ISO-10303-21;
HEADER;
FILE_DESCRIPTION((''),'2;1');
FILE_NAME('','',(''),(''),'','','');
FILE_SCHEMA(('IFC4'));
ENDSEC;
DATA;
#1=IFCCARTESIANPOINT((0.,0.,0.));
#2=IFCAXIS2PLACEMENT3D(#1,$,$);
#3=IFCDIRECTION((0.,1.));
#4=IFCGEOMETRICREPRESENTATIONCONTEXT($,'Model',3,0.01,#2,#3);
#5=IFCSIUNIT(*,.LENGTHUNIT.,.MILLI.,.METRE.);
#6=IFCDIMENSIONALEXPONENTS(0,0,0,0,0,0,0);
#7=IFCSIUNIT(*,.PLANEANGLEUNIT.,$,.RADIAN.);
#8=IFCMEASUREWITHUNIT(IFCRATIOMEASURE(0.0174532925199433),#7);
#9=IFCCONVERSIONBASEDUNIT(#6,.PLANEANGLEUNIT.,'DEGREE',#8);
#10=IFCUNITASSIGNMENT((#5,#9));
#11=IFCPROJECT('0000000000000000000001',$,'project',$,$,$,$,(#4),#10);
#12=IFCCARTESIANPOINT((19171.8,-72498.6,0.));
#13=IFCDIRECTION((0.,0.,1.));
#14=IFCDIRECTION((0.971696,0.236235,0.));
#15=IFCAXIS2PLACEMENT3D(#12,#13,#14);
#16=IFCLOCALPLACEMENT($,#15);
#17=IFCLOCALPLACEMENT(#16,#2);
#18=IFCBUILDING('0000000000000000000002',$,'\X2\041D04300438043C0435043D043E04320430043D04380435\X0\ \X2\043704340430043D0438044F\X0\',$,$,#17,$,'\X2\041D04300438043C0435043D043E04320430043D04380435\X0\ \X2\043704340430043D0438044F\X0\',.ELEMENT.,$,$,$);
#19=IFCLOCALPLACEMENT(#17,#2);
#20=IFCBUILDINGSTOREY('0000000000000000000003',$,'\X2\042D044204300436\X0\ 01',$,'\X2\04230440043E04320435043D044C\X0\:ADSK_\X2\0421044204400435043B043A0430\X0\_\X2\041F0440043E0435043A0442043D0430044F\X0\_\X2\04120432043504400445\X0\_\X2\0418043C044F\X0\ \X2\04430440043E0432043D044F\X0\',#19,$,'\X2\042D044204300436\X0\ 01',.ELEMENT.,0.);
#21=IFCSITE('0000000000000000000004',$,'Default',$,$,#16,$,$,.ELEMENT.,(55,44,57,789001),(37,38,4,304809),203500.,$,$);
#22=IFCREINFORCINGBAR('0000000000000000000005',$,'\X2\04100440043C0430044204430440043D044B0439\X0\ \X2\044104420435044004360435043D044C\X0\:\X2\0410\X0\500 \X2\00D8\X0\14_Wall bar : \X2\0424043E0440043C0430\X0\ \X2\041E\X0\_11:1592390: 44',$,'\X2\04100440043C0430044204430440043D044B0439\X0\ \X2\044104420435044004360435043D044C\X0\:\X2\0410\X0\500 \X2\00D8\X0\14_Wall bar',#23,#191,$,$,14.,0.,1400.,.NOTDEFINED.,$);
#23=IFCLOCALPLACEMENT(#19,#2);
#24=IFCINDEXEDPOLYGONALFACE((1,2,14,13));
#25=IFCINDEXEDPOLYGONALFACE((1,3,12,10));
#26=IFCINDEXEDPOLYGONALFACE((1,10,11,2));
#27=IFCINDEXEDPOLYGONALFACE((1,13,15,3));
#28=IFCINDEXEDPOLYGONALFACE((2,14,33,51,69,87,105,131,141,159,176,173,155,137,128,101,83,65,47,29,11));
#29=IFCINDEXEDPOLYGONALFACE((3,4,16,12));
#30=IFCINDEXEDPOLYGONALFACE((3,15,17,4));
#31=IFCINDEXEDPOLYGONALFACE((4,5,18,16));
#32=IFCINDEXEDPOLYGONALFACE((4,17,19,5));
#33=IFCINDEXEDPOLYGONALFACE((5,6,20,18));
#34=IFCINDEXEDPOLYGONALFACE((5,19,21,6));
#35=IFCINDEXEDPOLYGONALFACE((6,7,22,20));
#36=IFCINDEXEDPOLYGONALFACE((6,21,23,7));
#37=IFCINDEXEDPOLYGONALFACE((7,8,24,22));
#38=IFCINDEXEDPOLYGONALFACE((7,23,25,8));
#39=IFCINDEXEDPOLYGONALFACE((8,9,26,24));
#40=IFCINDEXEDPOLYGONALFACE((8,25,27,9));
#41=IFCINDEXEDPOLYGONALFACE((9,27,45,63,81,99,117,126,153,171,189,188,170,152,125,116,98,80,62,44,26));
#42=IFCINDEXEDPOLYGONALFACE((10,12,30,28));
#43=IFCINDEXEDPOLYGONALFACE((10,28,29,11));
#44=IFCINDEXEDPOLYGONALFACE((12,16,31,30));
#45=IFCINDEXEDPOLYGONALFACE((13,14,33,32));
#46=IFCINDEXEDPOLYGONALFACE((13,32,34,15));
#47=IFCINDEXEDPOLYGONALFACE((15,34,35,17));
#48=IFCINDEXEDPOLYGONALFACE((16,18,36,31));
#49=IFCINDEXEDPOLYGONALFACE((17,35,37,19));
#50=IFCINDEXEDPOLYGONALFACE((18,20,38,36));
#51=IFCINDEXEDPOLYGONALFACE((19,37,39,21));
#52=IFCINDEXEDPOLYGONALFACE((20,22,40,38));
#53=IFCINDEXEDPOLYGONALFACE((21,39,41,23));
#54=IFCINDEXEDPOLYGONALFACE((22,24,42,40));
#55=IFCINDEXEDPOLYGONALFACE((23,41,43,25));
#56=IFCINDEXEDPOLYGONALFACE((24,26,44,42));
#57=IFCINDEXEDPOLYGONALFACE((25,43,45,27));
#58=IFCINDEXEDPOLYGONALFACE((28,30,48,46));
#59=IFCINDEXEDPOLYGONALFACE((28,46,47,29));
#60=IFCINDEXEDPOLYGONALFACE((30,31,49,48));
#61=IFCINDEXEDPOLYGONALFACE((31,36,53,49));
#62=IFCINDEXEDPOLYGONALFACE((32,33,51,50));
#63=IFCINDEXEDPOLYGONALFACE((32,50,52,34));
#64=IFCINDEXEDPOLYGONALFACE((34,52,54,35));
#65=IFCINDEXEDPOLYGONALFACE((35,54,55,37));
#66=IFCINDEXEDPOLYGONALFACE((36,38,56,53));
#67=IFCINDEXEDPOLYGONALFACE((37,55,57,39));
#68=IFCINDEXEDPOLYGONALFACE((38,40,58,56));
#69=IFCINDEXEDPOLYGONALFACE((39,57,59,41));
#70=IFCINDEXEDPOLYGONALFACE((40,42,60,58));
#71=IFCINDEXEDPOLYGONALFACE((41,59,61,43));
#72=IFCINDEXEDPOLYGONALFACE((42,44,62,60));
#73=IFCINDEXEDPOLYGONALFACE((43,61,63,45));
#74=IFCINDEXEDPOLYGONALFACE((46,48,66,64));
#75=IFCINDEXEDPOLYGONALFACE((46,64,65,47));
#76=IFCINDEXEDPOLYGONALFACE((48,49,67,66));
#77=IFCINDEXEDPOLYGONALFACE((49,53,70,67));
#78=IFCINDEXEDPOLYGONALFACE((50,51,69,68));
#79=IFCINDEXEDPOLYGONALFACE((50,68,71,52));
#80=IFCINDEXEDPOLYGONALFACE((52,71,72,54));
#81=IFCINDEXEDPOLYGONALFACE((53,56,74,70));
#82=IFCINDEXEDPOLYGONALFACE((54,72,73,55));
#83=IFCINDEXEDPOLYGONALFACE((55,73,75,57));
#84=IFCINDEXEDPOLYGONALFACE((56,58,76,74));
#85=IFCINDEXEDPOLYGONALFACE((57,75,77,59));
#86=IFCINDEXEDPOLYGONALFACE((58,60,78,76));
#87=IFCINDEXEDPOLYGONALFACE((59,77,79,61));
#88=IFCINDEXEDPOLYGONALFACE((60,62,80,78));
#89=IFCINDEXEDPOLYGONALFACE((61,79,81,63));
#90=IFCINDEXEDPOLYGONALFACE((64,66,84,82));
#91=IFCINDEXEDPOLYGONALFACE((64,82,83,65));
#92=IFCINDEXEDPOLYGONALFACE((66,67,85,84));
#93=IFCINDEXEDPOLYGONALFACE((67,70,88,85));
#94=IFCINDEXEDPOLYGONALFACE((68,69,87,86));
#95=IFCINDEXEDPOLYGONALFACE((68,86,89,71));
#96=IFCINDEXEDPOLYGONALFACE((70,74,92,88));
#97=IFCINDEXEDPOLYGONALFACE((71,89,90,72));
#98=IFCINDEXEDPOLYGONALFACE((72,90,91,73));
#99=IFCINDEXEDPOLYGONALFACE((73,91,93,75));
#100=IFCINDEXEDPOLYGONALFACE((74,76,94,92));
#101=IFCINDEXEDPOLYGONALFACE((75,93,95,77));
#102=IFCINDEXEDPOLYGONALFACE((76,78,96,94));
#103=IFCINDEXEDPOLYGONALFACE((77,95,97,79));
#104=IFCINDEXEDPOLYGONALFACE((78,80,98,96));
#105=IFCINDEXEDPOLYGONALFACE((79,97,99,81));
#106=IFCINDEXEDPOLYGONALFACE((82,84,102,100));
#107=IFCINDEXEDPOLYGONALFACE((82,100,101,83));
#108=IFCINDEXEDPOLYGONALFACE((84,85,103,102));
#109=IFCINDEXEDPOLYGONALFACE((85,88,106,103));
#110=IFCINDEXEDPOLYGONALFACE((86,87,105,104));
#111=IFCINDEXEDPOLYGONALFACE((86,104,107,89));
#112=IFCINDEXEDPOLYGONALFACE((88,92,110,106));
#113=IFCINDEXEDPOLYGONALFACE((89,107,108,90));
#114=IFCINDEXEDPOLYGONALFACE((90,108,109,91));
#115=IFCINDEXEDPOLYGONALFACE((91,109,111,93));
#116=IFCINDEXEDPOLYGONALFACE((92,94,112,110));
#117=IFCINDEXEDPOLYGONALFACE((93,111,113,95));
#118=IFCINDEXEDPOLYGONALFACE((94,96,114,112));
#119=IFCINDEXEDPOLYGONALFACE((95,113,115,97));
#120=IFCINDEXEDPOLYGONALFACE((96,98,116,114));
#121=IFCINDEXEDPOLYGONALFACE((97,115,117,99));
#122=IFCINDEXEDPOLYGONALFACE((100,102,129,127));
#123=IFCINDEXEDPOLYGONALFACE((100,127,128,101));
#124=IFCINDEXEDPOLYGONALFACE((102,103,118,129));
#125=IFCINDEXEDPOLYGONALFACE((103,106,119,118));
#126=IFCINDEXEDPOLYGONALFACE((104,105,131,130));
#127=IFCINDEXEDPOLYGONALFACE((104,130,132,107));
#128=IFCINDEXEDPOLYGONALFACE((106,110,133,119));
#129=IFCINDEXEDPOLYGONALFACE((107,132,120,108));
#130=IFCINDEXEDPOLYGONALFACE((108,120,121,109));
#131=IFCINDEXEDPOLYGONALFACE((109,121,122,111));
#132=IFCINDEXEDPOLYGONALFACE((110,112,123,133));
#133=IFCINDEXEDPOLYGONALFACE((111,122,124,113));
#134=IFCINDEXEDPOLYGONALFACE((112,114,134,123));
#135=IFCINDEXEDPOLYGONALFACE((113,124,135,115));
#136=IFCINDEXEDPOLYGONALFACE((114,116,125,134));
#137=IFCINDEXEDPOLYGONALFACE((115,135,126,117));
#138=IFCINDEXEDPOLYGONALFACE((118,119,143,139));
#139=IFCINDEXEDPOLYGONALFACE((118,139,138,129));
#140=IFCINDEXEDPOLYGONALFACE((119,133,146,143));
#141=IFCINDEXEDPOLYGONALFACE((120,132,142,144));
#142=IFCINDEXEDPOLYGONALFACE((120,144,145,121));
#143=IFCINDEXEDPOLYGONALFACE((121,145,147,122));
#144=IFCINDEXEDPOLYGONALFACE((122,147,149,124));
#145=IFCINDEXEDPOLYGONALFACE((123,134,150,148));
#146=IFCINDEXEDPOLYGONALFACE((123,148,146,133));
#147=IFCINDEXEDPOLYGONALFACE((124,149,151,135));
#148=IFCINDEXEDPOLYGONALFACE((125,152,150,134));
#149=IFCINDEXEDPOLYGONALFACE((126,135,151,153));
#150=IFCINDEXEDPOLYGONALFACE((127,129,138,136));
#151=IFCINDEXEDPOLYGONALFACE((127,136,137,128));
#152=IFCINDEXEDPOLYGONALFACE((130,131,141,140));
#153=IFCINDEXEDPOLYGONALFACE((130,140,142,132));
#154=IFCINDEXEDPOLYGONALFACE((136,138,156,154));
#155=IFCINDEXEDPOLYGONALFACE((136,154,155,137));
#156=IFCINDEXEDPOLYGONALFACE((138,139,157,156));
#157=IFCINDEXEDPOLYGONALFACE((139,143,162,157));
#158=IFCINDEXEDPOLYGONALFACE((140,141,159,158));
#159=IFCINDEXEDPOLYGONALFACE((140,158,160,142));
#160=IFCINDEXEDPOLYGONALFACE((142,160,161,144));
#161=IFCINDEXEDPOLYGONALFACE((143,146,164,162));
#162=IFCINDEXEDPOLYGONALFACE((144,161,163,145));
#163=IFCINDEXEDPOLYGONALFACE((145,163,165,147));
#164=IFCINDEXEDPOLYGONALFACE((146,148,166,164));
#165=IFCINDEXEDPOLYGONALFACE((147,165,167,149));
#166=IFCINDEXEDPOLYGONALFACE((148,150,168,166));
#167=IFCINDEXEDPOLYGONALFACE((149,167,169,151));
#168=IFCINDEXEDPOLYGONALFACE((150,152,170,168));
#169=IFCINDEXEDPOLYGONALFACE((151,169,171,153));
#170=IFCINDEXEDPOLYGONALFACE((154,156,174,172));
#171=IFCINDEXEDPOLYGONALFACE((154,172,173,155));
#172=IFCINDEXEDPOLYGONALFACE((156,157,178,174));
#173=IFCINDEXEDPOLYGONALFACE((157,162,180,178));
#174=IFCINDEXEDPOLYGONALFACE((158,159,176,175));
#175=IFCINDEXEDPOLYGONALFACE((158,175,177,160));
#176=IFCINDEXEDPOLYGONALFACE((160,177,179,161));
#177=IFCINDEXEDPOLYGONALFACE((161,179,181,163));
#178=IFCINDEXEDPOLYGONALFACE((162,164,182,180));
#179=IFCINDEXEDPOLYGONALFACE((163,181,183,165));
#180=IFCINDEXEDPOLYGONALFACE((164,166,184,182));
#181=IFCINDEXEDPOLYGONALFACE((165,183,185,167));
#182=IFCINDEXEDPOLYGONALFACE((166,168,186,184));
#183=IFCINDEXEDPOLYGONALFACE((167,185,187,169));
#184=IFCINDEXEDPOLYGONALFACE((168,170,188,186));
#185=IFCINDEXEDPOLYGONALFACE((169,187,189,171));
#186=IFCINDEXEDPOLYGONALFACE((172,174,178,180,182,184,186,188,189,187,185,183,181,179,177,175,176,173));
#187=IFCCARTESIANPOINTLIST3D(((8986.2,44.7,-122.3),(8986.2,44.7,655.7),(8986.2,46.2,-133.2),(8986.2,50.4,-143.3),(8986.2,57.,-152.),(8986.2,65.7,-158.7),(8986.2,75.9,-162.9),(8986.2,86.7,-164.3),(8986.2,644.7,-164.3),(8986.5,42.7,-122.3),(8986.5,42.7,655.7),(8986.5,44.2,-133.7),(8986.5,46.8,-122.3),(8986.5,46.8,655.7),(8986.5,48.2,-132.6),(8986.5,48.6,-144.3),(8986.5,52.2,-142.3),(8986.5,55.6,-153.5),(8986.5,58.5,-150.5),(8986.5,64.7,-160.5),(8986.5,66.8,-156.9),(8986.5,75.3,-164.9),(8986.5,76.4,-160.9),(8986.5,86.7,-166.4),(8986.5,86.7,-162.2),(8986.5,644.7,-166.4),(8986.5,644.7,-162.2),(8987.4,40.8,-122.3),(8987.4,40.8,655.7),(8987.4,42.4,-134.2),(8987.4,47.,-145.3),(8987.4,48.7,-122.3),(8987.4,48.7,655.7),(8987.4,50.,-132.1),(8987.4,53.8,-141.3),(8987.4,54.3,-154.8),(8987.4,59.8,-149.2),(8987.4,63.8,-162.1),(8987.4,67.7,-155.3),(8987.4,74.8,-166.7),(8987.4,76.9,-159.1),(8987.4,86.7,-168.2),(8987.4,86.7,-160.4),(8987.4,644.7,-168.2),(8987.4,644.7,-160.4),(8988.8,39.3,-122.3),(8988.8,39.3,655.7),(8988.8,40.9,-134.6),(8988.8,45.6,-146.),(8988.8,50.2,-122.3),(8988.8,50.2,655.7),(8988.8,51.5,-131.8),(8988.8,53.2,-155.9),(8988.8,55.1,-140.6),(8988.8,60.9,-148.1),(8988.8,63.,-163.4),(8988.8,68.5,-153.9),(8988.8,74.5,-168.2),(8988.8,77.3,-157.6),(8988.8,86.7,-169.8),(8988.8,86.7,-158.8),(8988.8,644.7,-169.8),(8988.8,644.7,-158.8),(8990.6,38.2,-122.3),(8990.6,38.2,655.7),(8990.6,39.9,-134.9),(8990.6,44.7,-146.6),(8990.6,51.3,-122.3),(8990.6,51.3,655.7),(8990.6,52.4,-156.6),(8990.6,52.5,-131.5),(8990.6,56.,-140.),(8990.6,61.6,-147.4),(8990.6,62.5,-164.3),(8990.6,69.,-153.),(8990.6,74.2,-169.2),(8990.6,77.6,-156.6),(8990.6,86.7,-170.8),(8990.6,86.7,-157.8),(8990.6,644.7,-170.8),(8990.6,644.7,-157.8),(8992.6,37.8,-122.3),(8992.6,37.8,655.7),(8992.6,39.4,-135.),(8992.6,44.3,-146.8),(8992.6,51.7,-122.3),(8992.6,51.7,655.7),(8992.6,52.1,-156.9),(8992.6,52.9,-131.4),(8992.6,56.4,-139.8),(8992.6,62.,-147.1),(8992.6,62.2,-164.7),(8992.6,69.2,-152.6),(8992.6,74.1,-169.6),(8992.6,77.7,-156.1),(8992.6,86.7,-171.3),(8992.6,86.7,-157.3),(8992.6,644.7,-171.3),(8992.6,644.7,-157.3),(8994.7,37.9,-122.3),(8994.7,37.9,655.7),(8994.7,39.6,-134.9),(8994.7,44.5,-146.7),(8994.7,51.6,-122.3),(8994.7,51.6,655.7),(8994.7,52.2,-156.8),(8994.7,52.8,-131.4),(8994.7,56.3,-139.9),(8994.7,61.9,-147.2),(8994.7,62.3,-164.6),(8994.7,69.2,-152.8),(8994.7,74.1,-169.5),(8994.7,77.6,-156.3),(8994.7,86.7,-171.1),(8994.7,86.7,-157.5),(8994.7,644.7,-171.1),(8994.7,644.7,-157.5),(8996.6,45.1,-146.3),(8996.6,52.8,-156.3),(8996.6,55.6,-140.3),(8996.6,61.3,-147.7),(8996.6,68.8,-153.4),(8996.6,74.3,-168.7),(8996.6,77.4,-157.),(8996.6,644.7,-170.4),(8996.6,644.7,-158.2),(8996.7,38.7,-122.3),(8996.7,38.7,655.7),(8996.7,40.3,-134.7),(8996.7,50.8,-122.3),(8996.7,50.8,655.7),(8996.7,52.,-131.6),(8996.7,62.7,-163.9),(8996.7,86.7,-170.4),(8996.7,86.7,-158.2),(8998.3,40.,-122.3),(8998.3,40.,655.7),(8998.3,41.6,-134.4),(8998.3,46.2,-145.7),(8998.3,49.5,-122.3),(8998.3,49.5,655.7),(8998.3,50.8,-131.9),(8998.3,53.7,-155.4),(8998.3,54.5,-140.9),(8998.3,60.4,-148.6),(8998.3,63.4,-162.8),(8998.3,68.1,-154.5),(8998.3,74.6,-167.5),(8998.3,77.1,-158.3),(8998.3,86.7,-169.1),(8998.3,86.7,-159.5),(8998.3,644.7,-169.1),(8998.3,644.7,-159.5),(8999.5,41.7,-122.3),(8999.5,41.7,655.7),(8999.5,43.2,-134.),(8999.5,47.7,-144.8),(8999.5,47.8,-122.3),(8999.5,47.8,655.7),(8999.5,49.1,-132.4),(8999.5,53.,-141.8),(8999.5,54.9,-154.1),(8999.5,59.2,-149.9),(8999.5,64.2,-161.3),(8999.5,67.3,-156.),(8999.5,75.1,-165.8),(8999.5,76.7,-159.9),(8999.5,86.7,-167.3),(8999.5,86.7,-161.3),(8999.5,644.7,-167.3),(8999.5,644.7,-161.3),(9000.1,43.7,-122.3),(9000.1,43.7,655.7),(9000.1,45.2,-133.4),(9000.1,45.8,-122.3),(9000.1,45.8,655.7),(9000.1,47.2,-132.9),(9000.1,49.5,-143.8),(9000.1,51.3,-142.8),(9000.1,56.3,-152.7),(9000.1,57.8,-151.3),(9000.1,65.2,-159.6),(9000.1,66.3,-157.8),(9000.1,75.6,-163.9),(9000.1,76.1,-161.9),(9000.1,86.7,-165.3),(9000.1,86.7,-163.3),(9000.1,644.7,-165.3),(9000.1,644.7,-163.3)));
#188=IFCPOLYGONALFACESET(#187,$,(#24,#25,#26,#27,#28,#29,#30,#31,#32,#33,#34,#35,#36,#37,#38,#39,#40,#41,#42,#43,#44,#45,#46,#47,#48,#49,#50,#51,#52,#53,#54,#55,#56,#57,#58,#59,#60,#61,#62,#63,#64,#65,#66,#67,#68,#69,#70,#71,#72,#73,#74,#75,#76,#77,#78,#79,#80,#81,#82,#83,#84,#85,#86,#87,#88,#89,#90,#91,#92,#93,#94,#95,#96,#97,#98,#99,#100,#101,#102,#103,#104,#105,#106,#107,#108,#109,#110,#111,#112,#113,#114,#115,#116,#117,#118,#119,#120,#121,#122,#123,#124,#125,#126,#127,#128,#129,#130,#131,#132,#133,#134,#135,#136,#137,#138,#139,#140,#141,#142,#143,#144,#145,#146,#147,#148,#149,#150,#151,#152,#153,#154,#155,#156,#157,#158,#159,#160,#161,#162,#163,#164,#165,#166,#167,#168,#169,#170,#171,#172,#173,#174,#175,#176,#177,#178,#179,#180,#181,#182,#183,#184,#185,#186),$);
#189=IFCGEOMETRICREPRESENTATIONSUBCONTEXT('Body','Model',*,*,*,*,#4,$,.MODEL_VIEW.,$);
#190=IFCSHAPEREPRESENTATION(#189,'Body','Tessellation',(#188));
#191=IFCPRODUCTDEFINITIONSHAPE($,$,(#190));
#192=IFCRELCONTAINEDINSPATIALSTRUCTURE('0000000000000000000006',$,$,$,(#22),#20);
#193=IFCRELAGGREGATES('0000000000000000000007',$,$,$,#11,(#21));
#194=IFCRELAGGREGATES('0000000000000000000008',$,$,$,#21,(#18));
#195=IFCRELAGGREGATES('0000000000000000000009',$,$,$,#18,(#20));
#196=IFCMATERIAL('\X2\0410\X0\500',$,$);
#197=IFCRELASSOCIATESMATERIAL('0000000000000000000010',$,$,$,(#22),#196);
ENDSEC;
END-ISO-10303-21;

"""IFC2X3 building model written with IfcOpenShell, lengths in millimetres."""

from ifc_helpers import new_model, entity, si_unit, converted_unit, direction, frame, origin, place, context, subcontext, project, spatial, material, element, save


model = new_model("IFC2X3")

# Units and contexts
model_context = context("Model", 3, precision=0.01, world=origin(), true_north=direction((0.0, 1.0)))
body_context = subcontext(model_context, "Body", "Model", "MODEL_VIEW")
ifc_project = project(units=[si_unit("LENGTHUNIT", "METRE", prefix="MILLI"), converted_unit("PLANEANGLEUNIT", "DEGREE", entity("IfcRatioMeasure", 0.0174532925199433), si_unit("PLANEANGLEUNIT", "RADIAN"), dimensions=[0, 0, 0, 0, 0, 0, 0])], contexts=[model_context])

# Site, building, storey
site_placement = place(None, frame((19171.8, -72498.6, 0.0), z_axis=(0.0, 0.0, 1.0), x_axis=(0.971696, 0.236235, 0.0)))
site = spatial("IfcSite", under=ifc_project, at=site_placement, Name="Default", CompositionType="ELEMENT", RefLatitude=(55, 44, 57, 789001), RefLongitude=(37, 38, 4, 304809), RefElevation=203500.0)
building_placement = place(site_placement, origin())
building = spatial("IfcBuilding", under=site, at=building_placement, Name="Наименование здания", LongName="Наименование здания", CompositionType="ELEMENT")
storey_placement = place(building_placement, origin())
storey = spatial("IfcBuildingStorey", under=building, at=storey_placement, Name="Этаж 01", ObjectType="Уровень:ADSK_Стрелка_Проектная_Вверх_Имя уровня", LongName="Этаж 01", CompositionType="ELEMENT", Elevation=0.0)

# Reinforcing bar
ifc_material = material(Name="А500")
placement = place(storey_placement, origin())
element("IfcReinforcingBar", 1, at=placement, inside=storey, material=ifc_material, Name="Арматурный стержень:А500 Ø14_Wall bar : Форма О_11:1592390: 44", ObjectType="Арматурный стержень:А500 Ø14_Wall bar", BarLength=1400.0, BarRole="NOTDEFINED", CrossSectionArea=0.0, NominalDiameter=14.0, context=body_context, shape_type="AdvancedSweptSolid", body=[
    entity("IfcSweptDiskSolid", entity("IfcCompositeCurve", [entity("IfcCompositeCurveSegment", "CONTINUOUS", True, entity("IfcPolyline", [entity("IfcCartesianPoint", [8993.1, 44.7, 655.7]), entity("IfcCartesianPoint", [8993.1, 44.7, -122.3])])), entity("IfcCompositeCurveSegment", "CONTINUOUS", True, entity("IfcTrimmedCurve", entity("IfcCircle", entity("IfcAxis2Placement3D", entity("IfcCartesianPoint", [8993.1, 86.7, -122.3]), entity("IfcDirection", [1.0, 0.0, 0.0]), entity("IfcDirection", [0.0, 0.0, -1.0])), 42.0), [entity("IfcParameterValue", 270.0)], [entity("IfcParameterValue", 360.0)], True, "PARAMETER")), entity("IfcCompositeCurveSegment", "CONTINUOUS", True, entity("IfcPolyline", [entity("IfcCartesianPoint", [8993.1, 86.7, -164.3]), entity("IfcCartesianPoint", [8993.1, 644.7, -164.3])]))], False), 7.0, None, 0.0, 92.0),
])

save(model, "model.ifc")
